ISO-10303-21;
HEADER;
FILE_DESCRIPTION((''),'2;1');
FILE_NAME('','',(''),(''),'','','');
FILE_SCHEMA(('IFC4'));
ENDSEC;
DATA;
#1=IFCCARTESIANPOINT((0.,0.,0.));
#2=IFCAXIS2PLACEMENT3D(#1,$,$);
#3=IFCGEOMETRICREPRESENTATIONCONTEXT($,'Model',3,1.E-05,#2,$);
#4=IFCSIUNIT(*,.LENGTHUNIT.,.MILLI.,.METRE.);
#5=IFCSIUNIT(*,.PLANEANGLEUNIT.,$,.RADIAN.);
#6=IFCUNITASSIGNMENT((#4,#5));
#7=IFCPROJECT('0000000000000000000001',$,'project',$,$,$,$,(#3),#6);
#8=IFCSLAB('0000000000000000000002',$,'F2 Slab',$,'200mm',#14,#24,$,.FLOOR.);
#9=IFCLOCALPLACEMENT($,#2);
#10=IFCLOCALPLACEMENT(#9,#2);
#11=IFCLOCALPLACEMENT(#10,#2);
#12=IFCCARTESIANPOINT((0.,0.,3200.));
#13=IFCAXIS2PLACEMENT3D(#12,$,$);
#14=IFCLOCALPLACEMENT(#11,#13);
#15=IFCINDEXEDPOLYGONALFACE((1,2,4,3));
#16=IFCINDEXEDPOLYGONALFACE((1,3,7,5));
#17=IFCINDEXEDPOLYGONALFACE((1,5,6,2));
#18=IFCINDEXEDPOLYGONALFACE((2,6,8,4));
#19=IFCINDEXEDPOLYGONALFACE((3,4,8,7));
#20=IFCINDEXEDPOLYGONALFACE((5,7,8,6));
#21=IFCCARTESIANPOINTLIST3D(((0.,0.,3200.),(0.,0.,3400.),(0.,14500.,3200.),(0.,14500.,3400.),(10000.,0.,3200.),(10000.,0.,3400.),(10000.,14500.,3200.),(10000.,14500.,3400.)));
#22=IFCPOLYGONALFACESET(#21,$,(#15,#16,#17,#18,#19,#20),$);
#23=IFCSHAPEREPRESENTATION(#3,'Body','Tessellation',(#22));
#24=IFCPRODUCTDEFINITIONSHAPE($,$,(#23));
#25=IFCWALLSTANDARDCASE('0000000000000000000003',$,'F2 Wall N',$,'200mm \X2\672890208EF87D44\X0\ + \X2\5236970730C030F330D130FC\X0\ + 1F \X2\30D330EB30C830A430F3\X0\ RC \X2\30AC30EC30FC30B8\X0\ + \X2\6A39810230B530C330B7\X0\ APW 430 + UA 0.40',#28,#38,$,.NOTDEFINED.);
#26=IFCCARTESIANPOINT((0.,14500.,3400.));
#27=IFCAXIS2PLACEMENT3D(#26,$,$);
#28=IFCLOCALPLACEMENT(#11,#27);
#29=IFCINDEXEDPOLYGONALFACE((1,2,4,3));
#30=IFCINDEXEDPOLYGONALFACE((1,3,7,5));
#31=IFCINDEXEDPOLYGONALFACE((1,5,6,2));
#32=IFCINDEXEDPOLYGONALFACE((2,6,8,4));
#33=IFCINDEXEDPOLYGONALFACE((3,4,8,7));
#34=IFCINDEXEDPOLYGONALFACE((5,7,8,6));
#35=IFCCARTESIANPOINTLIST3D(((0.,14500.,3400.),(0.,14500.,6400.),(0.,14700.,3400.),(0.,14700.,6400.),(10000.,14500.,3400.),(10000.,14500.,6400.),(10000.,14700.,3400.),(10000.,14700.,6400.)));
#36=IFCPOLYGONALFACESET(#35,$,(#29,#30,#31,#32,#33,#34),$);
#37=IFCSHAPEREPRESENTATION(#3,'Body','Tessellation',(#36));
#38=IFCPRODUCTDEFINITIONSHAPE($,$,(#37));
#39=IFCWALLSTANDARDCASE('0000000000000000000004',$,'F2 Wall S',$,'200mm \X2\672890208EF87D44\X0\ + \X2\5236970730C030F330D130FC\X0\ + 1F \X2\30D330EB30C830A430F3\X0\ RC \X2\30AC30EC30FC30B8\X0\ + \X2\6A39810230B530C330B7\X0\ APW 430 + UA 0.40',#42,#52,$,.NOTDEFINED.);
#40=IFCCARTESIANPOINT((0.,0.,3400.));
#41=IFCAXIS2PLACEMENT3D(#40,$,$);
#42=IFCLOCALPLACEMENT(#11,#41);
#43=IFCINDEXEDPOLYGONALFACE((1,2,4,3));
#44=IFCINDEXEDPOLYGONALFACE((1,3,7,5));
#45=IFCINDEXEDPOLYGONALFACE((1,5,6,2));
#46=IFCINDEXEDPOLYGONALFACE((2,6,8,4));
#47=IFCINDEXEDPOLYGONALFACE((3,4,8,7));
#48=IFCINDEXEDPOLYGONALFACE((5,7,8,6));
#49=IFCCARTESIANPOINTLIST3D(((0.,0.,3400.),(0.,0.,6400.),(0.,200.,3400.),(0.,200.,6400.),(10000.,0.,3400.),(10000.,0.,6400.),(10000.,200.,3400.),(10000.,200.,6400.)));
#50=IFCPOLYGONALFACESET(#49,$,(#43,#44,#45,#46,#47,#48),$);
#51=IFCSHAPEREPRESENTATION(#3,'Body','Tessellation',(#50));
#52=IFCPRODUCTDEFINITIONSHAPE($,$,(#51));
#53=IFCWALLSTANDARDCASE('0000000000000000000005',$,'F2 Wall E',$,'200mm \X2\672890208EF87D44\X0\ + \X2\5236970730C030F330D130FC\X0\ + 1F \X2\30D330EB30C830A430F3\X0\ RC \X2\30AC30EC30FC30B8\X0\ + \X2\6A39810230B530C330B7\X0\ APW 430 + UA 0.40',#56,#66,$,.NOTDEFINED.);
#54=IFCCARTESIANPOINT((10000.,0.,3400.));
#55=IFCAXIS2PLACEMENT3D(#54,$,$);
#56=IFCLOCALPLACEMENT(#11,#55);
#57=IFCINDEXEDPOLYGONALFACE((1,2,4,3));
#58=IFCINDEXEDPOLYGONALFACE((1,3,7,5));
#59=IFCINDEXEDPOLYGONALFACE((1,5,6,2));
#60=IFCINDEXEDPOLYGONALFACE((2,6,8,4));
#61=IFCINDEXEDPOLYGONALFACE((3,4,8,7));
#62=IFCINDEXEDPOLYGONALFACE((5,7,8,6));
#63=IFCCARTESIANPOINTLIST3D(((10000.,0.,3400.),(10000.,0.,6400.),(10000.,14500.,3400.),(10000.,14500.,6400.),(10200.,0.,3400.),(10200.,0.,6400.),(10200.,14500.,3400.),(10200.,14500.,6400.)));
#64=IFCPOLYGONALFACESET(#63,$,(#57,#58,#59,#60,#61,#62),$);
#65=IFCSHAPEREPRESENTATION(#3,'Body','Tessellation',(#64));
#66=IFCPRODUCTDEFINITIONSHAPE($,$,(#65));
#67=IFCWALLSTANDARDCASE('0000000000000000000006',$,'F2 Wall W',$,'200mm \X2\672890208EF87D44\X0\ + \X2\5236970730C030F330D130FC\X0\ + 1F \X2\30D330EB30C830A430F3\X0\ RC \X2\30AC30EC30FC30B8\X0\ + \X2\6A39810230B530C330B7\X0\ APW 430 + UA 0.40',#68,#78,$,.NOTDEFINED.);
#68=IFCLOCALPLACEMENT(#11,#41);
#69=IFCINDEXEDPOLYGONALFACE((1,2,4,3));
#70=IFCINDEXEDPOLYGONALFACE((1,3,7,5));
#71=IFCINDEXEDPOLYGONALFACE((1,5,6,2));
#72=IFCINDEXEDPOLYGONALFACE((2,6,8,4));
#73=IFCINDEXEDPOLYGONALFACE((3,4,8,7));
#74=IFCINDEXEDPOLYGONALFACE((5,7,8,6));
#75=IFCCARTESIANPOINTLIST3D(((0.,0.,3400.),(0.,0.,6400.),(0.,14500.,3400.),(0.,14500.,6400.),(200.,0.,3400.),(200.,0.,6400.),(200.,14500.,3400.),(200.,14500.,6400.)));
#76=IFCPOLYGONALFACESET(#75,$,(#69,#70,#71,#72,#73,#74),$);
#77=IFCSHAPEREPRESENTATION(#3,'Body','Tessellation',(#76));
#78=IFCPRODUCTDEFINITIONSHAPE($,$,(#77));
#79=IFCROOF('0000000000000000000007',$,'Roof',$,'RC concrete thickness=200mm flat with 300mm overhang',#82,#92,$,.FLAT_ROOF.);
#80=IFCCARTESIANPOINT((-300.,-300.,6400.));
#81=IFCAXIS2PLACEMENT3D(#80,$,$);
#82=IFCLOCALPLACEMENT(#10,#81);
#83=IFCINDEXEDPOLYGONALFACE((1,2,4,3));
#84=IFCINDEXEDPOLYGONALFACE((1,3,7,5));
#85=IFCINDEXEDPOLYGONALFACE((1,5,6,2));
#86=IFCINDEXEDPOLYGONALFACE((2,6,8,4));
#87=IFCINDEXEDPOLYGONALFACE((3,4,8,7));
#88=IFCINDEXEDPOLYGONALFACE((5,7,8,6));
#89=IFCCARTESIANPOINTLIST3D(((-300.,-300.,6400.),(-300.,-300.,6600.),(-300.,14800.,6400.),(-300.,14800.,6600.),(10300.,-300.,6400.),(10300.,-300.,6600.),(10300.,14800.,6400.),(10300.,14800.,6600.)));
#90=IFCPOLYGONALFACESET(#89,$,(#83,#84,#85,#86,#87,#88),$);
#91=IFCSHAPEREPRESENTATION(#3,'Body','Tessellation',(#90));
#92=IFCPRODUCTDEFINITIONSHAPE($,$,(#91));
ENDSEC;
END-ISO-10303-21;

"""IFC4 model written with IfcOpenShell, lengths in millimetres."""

from ifc_helpers import new_model, si_unit, frame, frame_2d, origin, place, context, project, rectangle, extrude, element, save


model = new_model("IFC4")

# Units and contexts
model_context = context("Model", 3, precision=1e-05, world=origin())
ifc_project = project(units=[si_unit("LENGTHUNIT", "METRE", prefix="MILLI"), si_unit("PLANEANGLEUNIT", "RADIAN")], contexts=[model_context])

# Slab
placement_1 = place(None, origin())
placement_2 = place(placement_1, origin())
placement_3 = place(placement_2, origin())
slab_placement = place(placement_3, frame((0.0, 0.0, 3200.0)))
element("IfcSlab", 1, at=slab_placement, Name="F2 Slab", ObjectType="200mm", PredefinedType="FLOOR", context=model_context, shape_type="SweptSolid", body=[
    extrude(rectangle(XDim=10000.0, YDim=14500.0, at=frame_2d((5000.0, 7250.0))), frame((0.0, 0.0, 3200.0)), (0.0, 0.0, 1.0), 200.0),
])

# Walls
wall_1_placement = place(placement_3, frame((0.0, 14500.0, 3400.0)))
element("IfcWallStandardCase", 2, at=wall_1_placement, Name="F2 Wall N", ObjectType="200mm 木造軸組 + 制震ダンパー + 1F ビルトイン RC ガレージ + 樹脂サッシ APW 430 + UA 0.40", PredefinedType="NOTDEFINED", context=model_context, shape_type="SweptSolid", body=[
    extrude(rectangle(XDim=10000.0, YDim=200.0, at=frame_2d((5000.0, 100.0))), frame((0.0, 14500.0, 3400.0)), (0.0, 0.0, 1.0), 3000.0),
])
wall_2_placement = place(placement_3, frame((0.0, 0.0, 3400.0)))
element("IfcWallStandardCase", 3, at=wall_2_placement, Name="F2 Wall S", ObjectType="200mm 木造軸組 + 制震ダンパー + 1F ビルトイン RC ガレージ + 樹脂サッシ APW 430 + UA 0.40", PredefinedType="NOTDEFINED", context=model_context, shape_type="SweptSolid", body=[
    extrude(rectangle(XDim=10000.0, YDim=200.0, at=frame_2d((5000.0, 100.0))), frame((0.0, 0.0, 3400.0)), (0.0, 0.0, 1.0), 3000.0),
])
wall_3_placement = place(placement_3, frame((10000.0, 0.0, 3400.0)))
element("IfcWallStandardCase", 4, at=wall_3_placement, Name="F2 Wall E", ObjectType="200mm 木造軸組 + 制震ダンパー + 1F ビルトイン RC ガレージ + 樹脂サッシ APW 430 + UA 0.40", PredefinedType="NOTDEFINED", context=model_context, shape_type="SweptSolid", body=[
    extrude(rectangle(XDim=200.0, YDim=14500.0, at=frame_2d((100.0, 7250.0))), frame((10000.0, 0.0, 3400.0)), (0.0, 0.0, 1.0), 3000.0),
])
wall_4_placement = place(placement_3, frame((0.0, 0.0, 3400.0)))
element("IfcWallStandardCase", 5, at=wall_4_placement, Name="F2 Wall W", ObjectType="200mm 木造軸組 + 制震ダンパー + 1F ビルトイン RC ガレージ + 樹脂サッシ APW 430 + UA 0.40", PredefinedType="NOTDEFINED", context=model_context, shape_type="SweptSolid", body=[
    extrude(rectangle(XDim=200.0, YDim=14500.0, at=frame_2d((100.0, 7250.0))), frame((0.0, 0.0, 3400.0)), (0.0, 0.0, 1.0), 3000.0),
])

# Roof
roof_placement = place(placement_2, frame((-300.0, -300.0, 6400.0)))
element("IfcRoof", 6, at=roof_placement, Name="Roof", ObjectType="RC concrete thickness=200mm flat with 300mm overhang", PredefinedType="FLAT_ROOF", context=model_context, shape_type="SweptSolid", body=[
    extrude(rectangle(XDim=10600.0, YDim=15100.0, at=frame_2d((5300.0, 7550.0))), frame((-300.0, -300.0, 6400.0)), (0.0, 0.0, 1.0), 200.0),
])

save(model, "model.ifc")
